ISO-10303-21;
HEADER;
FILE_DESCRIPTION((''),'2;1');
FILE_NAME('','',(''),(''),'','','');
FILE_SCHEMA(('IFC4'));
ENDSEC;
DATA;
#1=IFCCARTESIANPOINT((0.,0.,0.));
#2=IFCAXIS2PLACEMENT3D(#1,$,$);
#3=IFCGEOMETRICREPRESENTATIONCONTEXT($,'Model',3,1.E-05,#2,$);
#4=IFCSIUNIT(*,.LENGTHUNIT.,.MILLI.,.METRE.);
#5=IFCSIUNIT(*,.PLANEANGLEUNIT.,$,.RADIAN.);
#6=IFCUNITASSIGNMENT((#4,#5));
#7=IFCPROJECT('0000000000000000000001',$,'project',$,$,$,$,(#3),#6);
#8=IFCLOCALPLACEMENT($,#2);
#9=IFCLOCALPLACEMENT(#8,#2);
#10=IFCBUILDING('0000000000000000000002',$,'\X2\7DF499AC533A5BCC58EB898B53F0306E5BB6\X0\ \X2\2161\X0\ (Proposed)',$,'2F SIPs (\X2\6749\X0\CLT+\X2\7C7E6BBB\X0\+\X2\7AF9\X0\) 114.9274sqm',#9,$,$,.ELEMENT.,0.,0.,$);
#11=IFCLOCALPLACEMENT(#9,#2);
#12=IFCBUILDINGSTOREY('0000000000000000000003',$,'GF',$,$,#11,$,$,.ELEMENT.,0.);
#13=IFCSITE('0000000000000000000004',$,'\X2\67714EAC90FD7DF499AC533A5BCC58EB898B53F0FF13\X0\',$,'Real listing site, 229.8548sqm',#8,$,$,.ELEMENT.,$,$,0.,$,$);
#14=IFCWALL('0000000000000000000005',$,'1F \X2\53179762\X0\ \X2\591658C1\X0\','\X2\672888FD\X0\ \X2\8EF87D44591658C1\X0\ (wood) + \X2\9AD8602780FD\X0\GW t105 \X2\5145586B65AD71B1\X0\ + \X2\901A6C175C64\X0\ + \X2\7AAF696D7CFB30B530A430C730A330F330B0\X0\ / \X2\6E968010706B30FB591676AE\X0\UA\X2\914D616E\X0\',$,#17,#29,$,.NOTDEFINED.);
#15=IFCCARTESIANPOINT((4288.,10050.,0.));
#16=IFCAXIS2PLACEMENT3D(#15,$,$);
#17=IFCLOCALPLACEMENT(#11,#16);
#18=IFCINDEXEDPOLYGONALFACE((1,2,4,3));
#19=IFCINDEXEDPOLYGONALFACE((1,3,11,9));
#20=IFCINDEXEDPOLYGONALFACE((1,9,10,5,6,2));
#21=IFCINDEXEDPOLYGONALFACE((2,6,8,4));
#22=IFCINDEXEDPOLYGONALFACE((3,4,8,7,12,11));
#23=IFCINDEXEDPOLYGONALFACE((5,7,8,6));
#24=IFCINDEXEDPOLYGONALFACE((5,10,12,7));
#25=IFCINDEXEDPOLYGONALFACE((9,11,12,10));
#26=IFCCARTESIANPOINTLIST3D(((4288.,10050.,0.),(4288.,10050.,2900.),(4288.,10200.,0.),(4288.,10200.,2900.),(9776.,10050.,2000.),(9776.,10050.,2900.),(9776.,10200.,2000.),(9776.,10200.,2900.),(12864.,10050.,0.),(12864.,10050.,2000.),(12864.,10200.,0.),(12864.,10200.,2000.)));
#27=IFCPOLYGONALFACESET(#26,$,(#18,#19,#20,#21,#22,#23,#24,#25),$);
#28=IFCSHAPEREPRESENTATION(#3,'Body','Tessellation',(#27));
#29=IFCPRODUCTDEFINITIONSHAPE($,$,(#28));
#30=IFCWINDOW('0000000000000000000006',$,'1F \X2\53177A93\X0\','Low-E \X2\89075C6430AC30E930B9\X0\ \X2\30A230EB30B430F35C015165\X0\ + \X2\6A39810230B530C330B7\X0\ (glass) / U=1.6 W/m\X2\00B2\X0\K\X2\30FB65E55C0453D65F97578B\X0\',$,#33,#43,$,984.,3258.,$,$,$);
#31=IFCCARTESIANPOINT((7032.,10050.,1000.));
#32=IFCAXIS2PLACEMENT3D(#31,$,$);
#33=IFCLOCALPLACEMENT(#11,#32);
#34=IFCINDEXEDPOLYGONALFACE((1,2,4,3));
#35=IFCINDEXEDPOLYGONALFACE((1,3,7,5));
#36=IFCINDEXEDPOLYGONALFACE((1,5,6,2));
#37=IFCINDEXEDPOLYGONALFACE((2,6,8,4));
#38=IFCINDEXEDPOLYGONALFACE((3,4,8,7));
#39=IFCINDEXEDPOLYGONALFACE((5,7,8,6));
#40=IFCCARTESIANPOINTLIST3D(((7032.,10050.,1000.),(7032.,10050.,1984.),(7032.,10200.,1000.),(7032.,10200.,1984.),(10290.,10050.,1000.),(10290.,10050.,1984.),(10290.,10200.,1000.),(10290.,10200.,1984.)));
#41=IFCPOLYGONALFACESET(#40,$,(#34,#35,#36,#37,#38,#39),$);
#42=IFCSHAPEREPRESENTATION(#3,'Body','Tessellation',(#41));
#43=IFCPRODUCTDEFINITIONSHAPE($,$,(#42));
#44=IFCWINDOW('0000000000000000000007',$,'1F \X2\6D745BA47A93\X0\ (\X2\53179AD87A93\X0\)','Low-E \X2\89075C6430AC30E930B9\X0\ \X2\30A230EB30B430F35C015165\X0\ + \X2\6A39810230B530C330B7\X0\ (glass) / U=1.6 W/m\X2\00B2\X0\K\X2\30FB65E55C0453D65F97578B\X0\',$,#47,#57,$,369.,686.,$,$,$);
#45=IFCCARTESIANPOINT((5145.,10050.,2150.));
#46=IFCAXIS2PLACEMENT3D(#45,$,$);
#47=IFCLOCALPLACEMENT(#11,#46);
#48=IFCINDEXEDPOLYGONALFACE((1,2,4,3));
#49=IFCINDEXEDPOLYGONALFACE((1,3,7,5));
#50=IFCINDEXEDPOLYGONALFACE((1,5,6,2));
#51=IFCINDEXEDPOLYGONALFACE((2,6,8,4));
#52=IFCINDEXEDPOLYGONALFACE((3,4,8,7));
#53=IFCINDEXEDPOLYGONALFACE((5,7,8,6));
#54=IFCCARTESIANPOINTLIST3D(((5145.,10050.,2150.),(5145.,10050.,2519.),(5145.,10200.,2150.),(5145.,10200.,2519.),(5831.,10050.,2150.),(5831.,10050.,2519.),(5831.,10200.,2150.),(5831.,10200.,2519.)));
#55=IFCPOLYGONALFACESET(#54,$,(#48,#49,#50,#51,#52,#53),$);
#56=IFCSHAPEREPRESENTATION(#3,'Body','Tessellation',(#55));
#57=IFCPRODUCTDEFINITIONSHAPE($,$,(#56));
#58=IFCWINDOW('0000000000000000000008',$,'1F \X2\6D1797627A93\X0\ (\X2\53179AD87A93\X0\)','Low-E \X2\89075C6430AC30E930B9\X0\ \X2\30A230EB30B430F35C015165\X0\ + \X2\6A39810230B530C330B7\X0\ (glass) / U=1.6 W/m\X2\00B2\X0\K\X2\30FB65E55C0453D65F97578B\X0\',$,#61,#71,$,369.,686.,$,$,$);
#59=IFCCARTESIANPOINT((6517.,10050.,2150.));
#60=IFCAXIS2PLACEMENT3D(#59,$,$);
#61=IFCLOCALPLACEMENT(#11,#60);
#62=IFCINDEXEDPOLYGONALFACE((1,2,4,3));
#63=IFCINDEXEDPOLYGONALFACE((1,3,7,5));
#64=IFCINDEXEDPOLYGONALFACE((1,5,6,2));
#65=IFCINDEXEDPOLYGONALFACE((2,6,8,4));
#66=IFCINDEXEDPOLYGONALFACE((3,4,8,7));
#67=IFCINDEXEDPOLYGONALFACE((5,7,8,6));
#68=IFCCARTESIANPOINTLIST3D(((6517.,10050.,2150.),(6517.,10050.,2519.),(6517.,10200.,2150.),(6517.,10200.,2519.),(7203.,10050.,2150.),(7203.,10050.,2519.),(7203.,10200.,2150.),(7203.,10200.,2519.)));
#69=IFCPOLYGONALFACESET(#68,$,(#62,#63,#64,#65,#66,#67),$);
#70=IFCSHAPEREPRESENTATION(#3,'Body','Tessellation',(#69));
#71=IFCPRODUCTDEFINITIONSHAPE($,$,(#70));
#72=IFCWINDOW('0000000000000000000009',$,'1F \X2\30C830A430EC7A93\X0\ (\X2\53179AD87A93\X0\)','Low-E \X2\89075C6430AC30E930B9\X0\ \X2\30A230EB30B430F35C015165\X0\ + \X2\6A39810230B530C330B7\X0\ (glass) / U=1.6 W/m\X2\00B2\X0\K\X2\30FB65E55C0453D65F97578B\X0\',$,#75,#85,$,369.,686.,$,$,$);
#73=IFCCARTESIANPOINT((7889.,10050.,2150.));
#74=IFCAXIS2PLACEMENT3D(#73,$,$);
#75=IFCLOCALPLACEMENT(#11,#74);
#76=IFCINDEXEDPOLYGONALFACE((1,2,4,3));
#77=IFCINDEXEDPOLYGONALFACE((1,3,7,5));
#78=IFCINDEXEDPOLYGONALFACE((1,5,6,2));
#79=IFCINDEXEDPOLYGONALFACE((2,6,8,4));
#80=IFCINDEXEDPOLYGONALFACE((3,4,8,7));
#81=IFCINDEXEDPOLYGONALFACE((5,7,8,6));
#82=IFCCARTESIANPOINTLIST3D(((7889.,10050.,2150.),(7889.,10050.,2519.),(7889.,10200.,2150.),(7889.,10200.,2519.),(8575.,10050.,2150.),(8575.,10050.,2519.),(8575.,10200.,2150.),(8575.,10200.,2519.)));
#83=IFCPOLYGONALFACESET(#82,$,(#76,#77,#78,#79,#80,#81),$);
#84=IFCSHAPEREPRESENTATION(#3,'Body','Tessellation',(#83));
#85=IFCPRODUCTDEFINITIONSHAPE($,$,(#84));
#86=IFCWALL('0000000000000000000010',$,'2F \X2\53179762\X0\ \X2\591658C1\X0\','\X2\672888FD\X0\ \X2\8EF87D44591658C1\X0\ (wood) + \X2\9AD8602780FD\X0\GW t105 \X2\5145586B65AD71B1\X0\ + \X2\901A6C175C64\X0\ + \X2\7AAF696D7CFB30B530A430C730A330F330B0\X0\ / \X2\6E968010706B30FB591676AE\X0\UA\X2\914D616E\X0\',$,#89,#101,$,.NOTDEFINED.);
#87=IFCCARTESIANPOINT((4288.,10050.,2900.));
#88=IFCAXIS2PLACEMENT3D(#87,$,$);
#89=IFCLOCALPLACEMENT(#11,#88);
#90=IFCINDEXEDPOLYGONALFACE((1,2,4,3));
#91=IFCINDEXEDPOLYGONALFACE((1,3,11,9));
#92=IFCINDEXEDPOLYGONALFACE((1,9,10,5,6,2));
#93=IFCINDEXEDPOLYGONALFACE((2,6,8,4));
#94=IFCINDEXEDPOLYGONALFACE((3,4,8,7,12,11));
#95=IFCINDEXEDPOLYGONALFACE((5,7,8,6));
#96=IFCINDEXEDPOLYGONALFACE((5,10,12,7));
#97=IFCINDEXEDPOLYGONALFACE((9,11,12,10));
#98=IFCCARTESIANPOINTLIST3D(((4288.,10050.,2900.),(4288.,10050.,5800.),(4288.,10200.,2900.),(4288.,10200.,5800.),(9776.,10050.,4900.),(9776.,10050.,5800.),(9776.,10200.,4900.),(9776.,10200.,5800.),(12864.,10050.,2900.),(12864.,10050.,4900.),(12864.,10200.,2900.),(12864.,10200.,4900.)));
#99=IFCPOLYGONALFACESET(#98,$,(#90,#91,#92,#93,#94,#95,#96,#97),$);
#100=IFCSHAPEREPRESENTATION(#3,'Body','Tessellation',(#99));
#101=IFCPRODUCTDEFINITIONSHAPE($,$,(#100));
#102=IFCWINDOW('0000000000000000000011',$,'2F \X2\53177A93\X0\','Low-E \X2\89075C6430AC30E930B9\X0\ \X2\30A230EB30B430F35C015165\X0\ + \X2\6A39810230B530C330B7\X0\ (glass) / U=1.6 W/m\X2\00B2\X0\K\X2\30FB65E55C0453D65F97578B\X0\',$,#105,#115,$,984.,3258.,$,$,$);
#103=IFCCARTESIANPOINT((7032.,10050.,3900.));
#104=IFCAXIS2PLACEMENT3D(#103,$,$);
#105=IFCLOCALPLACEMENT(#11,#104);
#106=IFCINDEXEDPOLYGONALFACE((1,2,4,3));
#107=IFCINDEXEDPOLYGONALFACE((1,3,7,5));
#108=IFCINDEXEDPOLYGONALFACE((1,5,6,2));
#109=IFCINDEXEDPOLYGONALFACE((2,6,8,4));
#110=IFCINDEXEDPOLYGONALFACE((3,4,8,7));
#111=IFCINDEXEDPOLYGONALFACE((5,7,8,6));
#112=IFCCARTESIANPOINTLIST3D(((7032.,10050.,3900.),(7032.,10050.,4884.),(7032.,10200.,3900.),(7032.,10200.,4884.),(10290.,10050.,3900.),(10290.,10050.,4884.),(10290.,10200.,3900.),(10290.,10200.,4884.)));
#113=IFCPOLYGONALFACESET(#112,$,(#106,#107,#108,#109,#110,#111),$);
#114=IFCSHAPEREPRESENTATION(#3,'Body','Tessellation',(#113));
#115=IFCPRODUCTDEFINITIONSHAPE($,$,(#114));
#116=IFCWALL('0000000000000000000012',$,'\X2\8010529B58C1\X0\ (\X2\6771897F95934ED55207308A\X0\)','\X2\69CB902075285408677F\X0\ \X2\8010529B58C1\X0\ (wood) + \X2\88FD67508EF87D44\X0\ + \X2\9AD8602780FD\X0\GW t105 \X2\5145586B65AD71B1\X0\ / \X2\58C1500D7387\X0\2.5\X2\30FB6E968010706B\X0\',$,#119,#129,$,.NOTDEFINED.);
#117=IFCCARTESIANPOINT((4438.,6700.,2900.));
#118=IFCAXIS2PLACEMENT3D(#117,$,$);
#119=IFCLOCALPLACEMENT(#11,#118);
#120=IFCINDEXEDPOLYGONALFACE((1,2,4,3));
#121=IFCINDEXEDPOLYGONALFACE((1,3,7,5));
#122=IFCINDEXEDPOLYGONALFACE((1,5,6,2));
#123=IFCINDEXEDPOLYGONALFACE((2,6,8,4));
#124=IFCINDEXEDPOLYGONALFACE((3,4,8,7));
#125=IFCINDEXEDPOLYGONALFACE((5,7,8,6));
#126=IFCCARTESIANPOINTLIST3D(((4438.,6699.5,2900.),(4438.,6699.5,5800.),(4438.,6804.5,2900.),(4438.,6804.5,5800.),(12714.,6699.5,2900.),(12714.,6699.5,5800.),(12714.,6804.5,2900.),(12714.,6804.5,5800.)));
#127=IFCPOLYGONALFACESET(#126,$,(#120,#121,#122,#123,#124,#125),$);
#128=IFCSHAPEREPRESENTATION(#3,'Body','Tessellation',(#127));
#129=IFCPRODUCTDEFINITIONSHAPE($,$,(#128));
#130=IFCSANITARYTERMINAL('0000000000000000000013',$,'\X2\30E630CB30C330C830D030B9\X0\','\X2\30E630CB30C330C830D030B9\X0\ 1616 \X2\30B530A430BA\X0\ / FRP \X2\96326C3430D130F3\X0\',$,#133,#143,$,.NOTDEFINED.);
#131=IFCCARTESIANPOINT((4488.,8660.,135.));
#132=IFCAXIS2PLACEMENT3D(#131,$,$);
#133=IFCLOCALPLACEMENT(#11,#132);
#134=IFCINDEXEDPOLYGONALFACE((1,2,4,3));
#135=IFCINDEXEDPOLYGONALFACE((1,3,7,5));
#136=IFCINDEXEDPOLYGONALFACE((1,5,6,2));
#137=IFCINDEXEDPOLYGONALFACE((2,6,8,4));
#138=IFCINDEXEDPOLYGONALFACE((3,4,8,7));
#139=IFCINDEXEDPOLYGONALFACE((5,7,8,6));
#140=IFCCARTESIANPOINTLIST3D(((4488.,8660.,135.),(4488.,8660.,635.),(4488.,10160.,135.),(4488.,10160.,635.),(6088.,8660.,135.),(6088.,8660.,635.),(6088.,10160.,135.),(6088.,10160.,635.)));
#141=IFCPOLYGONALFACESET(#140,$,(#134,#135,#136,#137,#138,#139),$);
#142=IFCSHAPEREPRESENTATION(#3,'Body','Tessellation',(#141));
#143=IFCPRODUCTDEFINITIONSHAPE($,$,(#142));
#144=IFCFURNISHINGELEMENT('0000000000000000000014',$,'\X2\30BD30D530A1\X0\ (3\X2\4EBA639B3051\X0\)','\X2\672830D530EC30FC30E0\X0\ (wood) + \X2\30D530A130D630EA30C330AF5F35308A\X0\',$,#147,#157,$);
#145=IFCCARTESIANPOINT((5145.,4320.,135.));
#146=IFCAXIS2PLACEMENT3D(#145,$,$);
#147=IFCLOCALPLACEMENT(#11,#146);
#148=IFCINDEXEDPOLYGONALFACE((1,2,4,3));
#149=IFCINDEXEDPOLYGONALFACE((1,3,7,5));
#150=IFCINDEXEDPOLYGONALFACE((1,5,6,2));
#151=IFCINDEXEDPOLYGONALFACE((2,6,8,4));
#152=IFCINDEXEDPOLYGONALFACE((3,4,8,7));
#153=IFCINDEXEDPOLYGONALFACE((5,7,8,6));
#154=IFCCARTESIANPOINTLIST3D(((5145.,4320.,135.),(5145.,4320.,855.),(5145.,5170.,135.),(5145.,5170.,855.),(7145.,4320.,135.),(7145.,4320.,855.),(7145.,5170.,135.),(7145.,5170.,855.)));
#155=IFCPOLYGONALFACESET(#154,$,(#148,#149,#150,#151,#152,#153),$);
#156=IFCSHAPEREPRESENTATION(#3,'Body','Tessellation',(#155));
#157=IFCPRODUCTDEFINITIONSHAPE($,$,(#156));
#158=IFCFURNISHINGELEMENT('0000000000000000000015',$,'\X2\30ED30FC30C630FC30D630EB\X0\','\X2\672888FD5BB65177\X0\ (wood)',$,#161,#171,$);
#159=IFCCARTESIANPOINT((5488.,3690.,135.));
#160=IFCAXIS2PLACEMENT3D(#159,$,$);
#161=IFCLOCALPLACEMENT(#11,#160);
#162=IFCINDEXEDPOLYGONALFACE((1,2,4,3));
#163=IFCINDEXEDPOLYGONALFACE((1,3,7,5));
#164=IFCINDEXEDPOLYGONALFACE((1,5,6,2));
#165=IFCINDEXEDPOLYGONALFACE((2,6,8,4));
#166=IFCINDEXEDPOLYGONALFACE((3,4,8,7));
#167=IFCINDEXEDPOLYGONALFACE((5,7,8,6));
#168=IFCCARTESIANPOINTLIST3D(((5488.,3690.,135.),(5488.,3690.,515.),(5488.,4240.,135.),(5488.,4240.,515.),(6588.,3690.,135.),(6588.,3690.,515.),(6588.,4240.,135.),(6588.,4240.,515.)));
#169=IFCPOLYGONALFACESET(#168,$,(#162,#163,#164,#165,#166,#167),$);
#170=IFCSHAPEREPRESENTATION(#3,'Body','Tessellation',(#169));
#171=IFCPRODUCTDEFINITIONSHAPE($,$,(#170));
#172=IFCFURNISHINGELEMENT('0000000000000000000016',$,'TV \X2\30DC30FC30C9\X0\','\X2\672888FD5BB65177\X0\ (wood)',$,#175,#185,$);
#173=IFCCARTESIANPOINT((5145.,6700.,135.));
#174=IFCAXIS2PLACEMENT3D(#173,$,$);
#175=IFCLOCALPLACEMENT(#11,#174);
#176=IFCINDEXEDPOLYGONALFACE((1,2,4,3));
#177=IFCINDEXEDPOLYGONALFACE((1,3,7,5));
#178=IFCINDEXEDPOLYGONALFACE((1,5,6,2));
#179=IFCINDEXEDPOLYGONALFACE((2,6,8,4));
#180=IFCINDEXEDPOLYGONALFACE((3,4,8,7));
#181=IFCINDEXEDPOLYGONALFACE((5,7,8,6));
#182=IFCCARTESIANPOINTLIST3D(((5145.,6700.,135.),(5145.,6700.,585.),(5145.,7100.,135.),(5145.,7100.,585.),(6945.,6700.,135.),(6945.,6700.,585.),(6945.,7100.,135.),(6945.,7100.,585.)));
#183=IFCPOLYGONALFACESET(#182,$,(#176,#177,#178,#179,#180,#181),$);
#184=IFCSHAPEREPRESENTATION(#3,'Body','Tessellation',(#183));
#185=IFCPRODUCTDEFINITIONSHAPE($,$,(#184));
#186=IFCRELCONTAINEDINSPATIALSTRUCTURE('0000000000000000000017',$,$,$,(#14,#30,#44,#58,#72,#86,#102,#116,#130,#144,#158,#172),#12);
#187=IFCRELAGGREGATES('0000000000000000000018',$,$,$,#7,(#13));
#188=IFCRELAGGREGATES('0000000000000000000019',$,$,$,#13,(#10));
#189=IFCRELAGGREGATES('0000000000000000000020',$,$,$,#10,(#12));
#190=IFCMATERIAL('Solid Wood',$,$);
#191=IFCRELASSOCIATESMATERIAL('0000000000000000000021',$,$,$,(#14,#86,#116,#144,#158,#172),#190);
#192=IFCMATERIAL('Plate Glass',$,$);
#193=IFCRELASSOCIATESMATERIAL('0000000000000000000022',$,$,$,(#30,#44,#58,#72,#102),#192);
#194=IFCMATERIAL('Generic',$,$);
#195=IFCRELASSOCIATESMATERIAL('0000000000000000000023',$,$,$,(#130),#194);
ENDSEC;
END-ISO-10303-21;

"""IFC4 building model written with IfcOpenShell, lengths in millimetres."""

from ifc_helpers import new_model, si_unit, frame, frame_2d, origin, place, context, project, spatial, rectangle, extrude, material, element, fill, save


model = new_model("IFC4")

# Units and contexts
model_context = context("Model", 3, precision=1e-05, world=origin())
ifc_project = project(units=[si_unit("LENGTHUNIT", "METRE", prefix="MILLI"), si_unit("PLANEANGLEUNIT", "RADIAN")], contexts=[model_context])

# Site, building, storey
site_placement = place(None, origin())
site = spatial("IfcSite", under=ifc_project, at=site_placement, Name="東京都練馬区富士見台３", ObjectType="Real listing site, 229.8548sqm", CompositionType="ELEMENT", RefElevation=0.0)
building_placement = place(site_placement, origin())
building = spatial("IfcBuilding", under=site, at=building_placement, Name="練馬区富士見台の家 Ⅱ (Proposed)", ObjectType="2F SIPs (杉CLT+籾殻+竹) 114.9274sqm", CompositionType="ELEMENT", ElevationOfRefHeight=0.0, ElevationOfTerrain=0.0)
storey_placement = place(building_placement, origin())
storey = spatial("IfcBuildingStorey", under=building, at=storey_placement, Name="GF", CompositionType="ELEMENT", Elevation=0.0)

# Wall, openings, windows
ifc_material_1 = material(Name="Solid Wood")
wall_1_placement = place(storey_placement, frame((4288.0, 10050.0, 0.0)))
wall_1 = element("IfcWall", 1, at=wall_1_placement, inside=storey, material=ifc_material_1, Name="1F 北面 外壁", Description="木製 軸組外壁 (wood) + 高性能GW t105 充填断熱 + 通気層 + 窯業系サイディング / 準耐火・外皮UA配慮", PredefinedType="NOTDEFINED", context=model_context, shape_type="SweptSolid", body=[
    extrude(rectangle(XDim=8576.0, YDim=150.0, at=frame_2d((4288.0, 75.0))), frame((4288.0, 10050.0, 0.0)), (0.0, 0.0, 1.0), 2900.0),
])
opening_1_placement = place(storey_placement, frame((7032.0, 10050.0, 1000.0)))
opening_1 = element("IfcOpeningElement", 2, at=opening_1_placement, cuts=wall_1, PredefinedType="NOTDEFINED", context=model_context, shape_type="SweptSolid", body=[
    extrude(rectangle(XDim=3258.0, YDim=150.0, at=frame_2d((1629.0, 75.0))), frame((7032.0, 10050.0, 1000.0)), (0.0, 0.0, 1.0), 984.0),
])
opening_2_placement = place(storey_placement, frame((5145.0, 10050.0, 2150.0)))
opening_2 = element("IfcOpeningElement", 3, at=opening_2_placement, cuts=wall_1, PredefinedType="NOTDEFINED", context=model_context, shape_type="SweptSolid", body=[
    extrude(rectangle(XDim=686.0, YDim=150.0, at=frame_2d((343.0, 75.0))), frame((5145.0, 10050.0, 2150.0)), (0.0, 0.0, 1.0), 369.0),
])
opening_3_placement = place(storey_placement, frame((6517.0, 10050.0, 2150.0)))
opening_3 = element("IfcOpeningElement", 4, at=opening_3_placement, cuts=wall_1, PredefinedType="NOTDEFINED", context=model_context, shape_type="SweptSolid", body=[
    extrude(rectangle(XDim=686.0, YDim=150.0, at=frame_2d((343.0, 75.0))), frame((6517.0, 10050.0, 2150.0)), (0.0, 0.0, 1.0), 369.0),
])
opening_4_placement = place(storey_placement, frame((7889.0, 10050.0, 2150.0)))
opening_4 = element("IfcOpeningElement", 5, at=opening_4_placement, cuts=wall_1, PredefinedType="NOTDEFINED", context=model_context, shape_type="SweptSolid", body=[
    extrude(rectangle(XDim=686.0, YDim=150.0, at=frame_2d((343.0, 75.0))), frame((7889.0, 10050.0, 2150.0)), (0.0, 0.0, 1.0), 369.0),
])
ifc_material_2 = material(Name="Plate Glass")
window_1_placement = place(storey_placement, frame((7032.0, 10050.0, 1000.0)))
window_1 = element("IfcWindow", 6, at=window_1_placement, inside=storey, material=ifc_material_2, Name="1F 北窓", Description="Low-E 複層ガラス アルゴン封入 + 樹脂サッシ (glass) / U=1.6 W/m²K・日射取得型", OverallHeight=984.0, OverallWidth=3258.0, context=model_context, shape_type="SweptSolid", body=[
    extrude(rectangle(XDim=3258.0, YDim=150.0, at=frame_2d((1629.0, 75.0))), frame((7032.0, 10050.0, 1000.0)), (0.0, 0.0, 1.0), 984.0),
])
fill(opening_1, window_1)
window_2_placement = place(storey_placement, frame((5145.0, 10050.0, 2150.0)))
window_2 = element("IfcWindow", 7, at=window_2_placement, inside=storey, material=ifc_material_2, Name="1F 浴室窓 (北高窓)", Description="Low-E 複層ガラス アルゴン封入 + 樹脂サッシ (glass) / U=1.6 W/m²K・日射取得型", OverallHeight=369.0, OverallWidth=686.0, context=model_context, shape_type="SweptSolid", body=[
    extrude(rectangle(XDim=686.0, YDim=150.0, at=frame_2d((343.0, 75.0))), frame((5145.0, 10050.0, 2150.0)), (0.0, 0.0, 1.0), 369.0),
])
fill(opening_2, window_2)
window_3_placement = place(storey_placement, frame((6517.0, 10050.0, 2150.0)))
window_3 = element("IfcWindow", 8, at=window_3_placement, inside=storey, material=ifc_material_2, Name="1F 洗面窓 (北高窓)", Description="Low-E 複層ガラス アルゴン封入 + 樹脂サッシ (glass) / U=1.6 W/m²K・日射取得型", OverallHeight=369.0, OverallWidth=686.0, context=model_context, shape_type="SweptSolid", body=[
    extrude(rectangle(XDim=686.0, YDim=150.0, at=frame_2d((343.0, 75.0))), frame((6517.0, 10050.0, 2150.0)), (0.0, 0.0, 1.0), 369.0),
])
fill(opening_3, window_3)
window_4_placement = place(storey_placement, frame((7889.0, 10050.0, 2150.0)))
window_4 = element("IfcWindow", 9, at=window_4_placement, inside=storey, material=ifc_material_2, Name="1F トイレ窓 (北高窓)", Description="Low-E 複層ガラス アルゴン封入 + 樹脂サッシ (glass) / U=1.6 W/m²K・日射取得型", OverallHeight=369.0, OverallWidth=686.0, context=model_context, shape_type="SweptSolid", body=[
    extrude(rectangle(XDim=686.0, YDim=150.0, at=frame_2d((343.0, 75.0))), frame((7889.0, 10050.0, 2150.0)), (0.0, 0.0, 1.0), 369.0),
])
fill(opening_4, window_4)

# Wall, opening, window
wall_2_placement = place(storey_placement, frame((4288.0, 10050.0, 2900.0)))
wall_2 = element("IfcWall", 10, at=wall_2_placement, inside=storey, material=ifc_material_1, Name="2F 北面 外壁", Description="木製 軸組外壁 (wood) + 高性能GW t105 充填断熱 + 通気層 + 窯業系サイディング / 準耐火・外皮UA配慮", PredefinedType="NOTDEFINED", context=model_context, shape_type="SweptSolid", body=[
    extrude(rectangle(XDim=8576.0, YDim=150.0, at=frame_2d((4288.0, 75.0))), frame((4288.0, 10050.0, 2900.0)), (0.0, 0.0, 1.0), 2900.0),
])
opening_5_placement = place(storey_placement, frame((7032.0, 10050.0, 3900.0)))
opening_5 = element("IfcOpeningElement", 11, at=opening_5_placement, cuts=wall_2, PredefinedType="NOTDEFINED", context=model_context, shape_type="SweptSolid", body=[
    extrude(rectangle(XDim=3258.0, YDim=150.0, at=frame_2d((1629.0, 75.0))), frame((7032.0, 10050.0, 3900.0)), (0.0, 0.0, 1.0), 984.0),
])
window_5_placement = place(storey_placement, frame((7032.0, 10050.0, 3900.0)))
window_5 = element("IfcWindow", 12, at=window_5_placement, inside=storey, material=ifc_material_2, Name="2F 北窓", Description="Low-E 複層ガラス アルゴン封入 + 樹脂サッシ (glass) / U=1.6 W/m²K・日射取得型", OverallHeight=984.0, OverallWidth=3258.0, context=model_context, shape_type="SweptSolid", body=[
    extrude(rectangle(XDim=3258.0, YDim=150.0, at=frame_2d((1629.0, 75.0))), frame((7032.0, 10050.0, 3900.0)), (0.0, 0.0, 1.0), 984.0),
])
fill(opening_5, window_5)

# Wall
wall_3_placement = place(storey_placement, frame((4438.0, 6700.0, 2900.0)))
element("IfcWall", 13, at=wall_3_placement, inside=storey, material=ifc_material_1, Name="耐力壁 (東西間仕切り)", Description="構造用合板 耐力壁 (wood) + 製材軸組 + 高性能GW t105 充填断熱 / 壁倍率2.5・準耐火", PredefinedType="NOTDEFINED", context=model_context, shape_type="SweptSolid", body=[
    extrude(rectangle(XDim=8276.0, YDim=105.0, at=frame_2d((4138.0, 52.0))), frame((4438.0, 6700.0, 2900.0)), (0.0, 0.0, 1.0), 2900.0),
])

# Sanitary terminal
ifc_material_3 = material(Name="Generic")
sanitary_terminal_placement = place(storey_placement, frame((4488.0, 8660.0, 135.0)))
element("IfcSanitaryTerminal", 14, at=sanitary_terminal_placement, inside=storey, material=ifc_material_3, Name="ユニットバス", Description="ユニットバス 1616 サイズ / FRP 防水パン", PredefinedType="NOTDEFINED", context=model_context, shape_type="SweptSolid", body=[
    extrude(rectangle(XDim=1600.0, YDim=1500.0, at=frame_2d((800.0, 750.0))), frame((4488.0, 8660.0, 135.0)), (0.0, 0.0, 1.0), 500.0),
])

# Furnishing elements
furnishing_1_placement = place(storey_placement, frame((5145.0, 4320.0, 135.0)))
element("IfcFurnishingElement", 15, at=furnishing_1_placement, inside=storey, material=ifc_material_1, Name="ソファ (3人掛け)", Description="木フレーム (wood) + ファブリック張り", context=model_context, shape_type="SweptSolid", body=[
    extrude(rectangle(XDim=2000.0, YDim=850.0, at=frame_2d((1000.0, 425.0))), frame((5145.0, 4320.0, 135.0)), (0.0, 0.0, 1.0), 720.0),
])
furnishing_2_placement = place(storey_placement, frame((5488.0, 3690.0, 135.0)))
element("IfcFurnishingElement", 16, at=furnishing_2_placement, inside=storey, material=ifc_material_1, Name="ローテーブル", Description="木製家具 (wood)", context=model_context, shape_type="SweptSolid", body=[
    extrude(rectangle(XDim=1100.0, YDim=550.0, at=frame_2d((550.0, 275.0))), frame((5488.0, 3690.0, 135.0)), (0.0, 0.0, 1.0), 380.0),
])
furnishing_3_placement = place(storey_placement, frame((5145.0, 6700.0, 135.0)))
element("IfcFurnishingElement", 17, at=furnishing_3_placement, inside=storey, material=ifc_material_1, Name="TV ボード", Description="木製家具 (wood)", context=model_context, shape_type="SweptSolid", body=[
    extrude(rectangle(XDim=1800.0, YDim=400.0, at=frame_2d((900.0, 200.0))), frame((5145.0, 6700.0, 135.0)), (0.0, 0.0, 1.0), 450.0),
])

save(model, "model.ifc")
